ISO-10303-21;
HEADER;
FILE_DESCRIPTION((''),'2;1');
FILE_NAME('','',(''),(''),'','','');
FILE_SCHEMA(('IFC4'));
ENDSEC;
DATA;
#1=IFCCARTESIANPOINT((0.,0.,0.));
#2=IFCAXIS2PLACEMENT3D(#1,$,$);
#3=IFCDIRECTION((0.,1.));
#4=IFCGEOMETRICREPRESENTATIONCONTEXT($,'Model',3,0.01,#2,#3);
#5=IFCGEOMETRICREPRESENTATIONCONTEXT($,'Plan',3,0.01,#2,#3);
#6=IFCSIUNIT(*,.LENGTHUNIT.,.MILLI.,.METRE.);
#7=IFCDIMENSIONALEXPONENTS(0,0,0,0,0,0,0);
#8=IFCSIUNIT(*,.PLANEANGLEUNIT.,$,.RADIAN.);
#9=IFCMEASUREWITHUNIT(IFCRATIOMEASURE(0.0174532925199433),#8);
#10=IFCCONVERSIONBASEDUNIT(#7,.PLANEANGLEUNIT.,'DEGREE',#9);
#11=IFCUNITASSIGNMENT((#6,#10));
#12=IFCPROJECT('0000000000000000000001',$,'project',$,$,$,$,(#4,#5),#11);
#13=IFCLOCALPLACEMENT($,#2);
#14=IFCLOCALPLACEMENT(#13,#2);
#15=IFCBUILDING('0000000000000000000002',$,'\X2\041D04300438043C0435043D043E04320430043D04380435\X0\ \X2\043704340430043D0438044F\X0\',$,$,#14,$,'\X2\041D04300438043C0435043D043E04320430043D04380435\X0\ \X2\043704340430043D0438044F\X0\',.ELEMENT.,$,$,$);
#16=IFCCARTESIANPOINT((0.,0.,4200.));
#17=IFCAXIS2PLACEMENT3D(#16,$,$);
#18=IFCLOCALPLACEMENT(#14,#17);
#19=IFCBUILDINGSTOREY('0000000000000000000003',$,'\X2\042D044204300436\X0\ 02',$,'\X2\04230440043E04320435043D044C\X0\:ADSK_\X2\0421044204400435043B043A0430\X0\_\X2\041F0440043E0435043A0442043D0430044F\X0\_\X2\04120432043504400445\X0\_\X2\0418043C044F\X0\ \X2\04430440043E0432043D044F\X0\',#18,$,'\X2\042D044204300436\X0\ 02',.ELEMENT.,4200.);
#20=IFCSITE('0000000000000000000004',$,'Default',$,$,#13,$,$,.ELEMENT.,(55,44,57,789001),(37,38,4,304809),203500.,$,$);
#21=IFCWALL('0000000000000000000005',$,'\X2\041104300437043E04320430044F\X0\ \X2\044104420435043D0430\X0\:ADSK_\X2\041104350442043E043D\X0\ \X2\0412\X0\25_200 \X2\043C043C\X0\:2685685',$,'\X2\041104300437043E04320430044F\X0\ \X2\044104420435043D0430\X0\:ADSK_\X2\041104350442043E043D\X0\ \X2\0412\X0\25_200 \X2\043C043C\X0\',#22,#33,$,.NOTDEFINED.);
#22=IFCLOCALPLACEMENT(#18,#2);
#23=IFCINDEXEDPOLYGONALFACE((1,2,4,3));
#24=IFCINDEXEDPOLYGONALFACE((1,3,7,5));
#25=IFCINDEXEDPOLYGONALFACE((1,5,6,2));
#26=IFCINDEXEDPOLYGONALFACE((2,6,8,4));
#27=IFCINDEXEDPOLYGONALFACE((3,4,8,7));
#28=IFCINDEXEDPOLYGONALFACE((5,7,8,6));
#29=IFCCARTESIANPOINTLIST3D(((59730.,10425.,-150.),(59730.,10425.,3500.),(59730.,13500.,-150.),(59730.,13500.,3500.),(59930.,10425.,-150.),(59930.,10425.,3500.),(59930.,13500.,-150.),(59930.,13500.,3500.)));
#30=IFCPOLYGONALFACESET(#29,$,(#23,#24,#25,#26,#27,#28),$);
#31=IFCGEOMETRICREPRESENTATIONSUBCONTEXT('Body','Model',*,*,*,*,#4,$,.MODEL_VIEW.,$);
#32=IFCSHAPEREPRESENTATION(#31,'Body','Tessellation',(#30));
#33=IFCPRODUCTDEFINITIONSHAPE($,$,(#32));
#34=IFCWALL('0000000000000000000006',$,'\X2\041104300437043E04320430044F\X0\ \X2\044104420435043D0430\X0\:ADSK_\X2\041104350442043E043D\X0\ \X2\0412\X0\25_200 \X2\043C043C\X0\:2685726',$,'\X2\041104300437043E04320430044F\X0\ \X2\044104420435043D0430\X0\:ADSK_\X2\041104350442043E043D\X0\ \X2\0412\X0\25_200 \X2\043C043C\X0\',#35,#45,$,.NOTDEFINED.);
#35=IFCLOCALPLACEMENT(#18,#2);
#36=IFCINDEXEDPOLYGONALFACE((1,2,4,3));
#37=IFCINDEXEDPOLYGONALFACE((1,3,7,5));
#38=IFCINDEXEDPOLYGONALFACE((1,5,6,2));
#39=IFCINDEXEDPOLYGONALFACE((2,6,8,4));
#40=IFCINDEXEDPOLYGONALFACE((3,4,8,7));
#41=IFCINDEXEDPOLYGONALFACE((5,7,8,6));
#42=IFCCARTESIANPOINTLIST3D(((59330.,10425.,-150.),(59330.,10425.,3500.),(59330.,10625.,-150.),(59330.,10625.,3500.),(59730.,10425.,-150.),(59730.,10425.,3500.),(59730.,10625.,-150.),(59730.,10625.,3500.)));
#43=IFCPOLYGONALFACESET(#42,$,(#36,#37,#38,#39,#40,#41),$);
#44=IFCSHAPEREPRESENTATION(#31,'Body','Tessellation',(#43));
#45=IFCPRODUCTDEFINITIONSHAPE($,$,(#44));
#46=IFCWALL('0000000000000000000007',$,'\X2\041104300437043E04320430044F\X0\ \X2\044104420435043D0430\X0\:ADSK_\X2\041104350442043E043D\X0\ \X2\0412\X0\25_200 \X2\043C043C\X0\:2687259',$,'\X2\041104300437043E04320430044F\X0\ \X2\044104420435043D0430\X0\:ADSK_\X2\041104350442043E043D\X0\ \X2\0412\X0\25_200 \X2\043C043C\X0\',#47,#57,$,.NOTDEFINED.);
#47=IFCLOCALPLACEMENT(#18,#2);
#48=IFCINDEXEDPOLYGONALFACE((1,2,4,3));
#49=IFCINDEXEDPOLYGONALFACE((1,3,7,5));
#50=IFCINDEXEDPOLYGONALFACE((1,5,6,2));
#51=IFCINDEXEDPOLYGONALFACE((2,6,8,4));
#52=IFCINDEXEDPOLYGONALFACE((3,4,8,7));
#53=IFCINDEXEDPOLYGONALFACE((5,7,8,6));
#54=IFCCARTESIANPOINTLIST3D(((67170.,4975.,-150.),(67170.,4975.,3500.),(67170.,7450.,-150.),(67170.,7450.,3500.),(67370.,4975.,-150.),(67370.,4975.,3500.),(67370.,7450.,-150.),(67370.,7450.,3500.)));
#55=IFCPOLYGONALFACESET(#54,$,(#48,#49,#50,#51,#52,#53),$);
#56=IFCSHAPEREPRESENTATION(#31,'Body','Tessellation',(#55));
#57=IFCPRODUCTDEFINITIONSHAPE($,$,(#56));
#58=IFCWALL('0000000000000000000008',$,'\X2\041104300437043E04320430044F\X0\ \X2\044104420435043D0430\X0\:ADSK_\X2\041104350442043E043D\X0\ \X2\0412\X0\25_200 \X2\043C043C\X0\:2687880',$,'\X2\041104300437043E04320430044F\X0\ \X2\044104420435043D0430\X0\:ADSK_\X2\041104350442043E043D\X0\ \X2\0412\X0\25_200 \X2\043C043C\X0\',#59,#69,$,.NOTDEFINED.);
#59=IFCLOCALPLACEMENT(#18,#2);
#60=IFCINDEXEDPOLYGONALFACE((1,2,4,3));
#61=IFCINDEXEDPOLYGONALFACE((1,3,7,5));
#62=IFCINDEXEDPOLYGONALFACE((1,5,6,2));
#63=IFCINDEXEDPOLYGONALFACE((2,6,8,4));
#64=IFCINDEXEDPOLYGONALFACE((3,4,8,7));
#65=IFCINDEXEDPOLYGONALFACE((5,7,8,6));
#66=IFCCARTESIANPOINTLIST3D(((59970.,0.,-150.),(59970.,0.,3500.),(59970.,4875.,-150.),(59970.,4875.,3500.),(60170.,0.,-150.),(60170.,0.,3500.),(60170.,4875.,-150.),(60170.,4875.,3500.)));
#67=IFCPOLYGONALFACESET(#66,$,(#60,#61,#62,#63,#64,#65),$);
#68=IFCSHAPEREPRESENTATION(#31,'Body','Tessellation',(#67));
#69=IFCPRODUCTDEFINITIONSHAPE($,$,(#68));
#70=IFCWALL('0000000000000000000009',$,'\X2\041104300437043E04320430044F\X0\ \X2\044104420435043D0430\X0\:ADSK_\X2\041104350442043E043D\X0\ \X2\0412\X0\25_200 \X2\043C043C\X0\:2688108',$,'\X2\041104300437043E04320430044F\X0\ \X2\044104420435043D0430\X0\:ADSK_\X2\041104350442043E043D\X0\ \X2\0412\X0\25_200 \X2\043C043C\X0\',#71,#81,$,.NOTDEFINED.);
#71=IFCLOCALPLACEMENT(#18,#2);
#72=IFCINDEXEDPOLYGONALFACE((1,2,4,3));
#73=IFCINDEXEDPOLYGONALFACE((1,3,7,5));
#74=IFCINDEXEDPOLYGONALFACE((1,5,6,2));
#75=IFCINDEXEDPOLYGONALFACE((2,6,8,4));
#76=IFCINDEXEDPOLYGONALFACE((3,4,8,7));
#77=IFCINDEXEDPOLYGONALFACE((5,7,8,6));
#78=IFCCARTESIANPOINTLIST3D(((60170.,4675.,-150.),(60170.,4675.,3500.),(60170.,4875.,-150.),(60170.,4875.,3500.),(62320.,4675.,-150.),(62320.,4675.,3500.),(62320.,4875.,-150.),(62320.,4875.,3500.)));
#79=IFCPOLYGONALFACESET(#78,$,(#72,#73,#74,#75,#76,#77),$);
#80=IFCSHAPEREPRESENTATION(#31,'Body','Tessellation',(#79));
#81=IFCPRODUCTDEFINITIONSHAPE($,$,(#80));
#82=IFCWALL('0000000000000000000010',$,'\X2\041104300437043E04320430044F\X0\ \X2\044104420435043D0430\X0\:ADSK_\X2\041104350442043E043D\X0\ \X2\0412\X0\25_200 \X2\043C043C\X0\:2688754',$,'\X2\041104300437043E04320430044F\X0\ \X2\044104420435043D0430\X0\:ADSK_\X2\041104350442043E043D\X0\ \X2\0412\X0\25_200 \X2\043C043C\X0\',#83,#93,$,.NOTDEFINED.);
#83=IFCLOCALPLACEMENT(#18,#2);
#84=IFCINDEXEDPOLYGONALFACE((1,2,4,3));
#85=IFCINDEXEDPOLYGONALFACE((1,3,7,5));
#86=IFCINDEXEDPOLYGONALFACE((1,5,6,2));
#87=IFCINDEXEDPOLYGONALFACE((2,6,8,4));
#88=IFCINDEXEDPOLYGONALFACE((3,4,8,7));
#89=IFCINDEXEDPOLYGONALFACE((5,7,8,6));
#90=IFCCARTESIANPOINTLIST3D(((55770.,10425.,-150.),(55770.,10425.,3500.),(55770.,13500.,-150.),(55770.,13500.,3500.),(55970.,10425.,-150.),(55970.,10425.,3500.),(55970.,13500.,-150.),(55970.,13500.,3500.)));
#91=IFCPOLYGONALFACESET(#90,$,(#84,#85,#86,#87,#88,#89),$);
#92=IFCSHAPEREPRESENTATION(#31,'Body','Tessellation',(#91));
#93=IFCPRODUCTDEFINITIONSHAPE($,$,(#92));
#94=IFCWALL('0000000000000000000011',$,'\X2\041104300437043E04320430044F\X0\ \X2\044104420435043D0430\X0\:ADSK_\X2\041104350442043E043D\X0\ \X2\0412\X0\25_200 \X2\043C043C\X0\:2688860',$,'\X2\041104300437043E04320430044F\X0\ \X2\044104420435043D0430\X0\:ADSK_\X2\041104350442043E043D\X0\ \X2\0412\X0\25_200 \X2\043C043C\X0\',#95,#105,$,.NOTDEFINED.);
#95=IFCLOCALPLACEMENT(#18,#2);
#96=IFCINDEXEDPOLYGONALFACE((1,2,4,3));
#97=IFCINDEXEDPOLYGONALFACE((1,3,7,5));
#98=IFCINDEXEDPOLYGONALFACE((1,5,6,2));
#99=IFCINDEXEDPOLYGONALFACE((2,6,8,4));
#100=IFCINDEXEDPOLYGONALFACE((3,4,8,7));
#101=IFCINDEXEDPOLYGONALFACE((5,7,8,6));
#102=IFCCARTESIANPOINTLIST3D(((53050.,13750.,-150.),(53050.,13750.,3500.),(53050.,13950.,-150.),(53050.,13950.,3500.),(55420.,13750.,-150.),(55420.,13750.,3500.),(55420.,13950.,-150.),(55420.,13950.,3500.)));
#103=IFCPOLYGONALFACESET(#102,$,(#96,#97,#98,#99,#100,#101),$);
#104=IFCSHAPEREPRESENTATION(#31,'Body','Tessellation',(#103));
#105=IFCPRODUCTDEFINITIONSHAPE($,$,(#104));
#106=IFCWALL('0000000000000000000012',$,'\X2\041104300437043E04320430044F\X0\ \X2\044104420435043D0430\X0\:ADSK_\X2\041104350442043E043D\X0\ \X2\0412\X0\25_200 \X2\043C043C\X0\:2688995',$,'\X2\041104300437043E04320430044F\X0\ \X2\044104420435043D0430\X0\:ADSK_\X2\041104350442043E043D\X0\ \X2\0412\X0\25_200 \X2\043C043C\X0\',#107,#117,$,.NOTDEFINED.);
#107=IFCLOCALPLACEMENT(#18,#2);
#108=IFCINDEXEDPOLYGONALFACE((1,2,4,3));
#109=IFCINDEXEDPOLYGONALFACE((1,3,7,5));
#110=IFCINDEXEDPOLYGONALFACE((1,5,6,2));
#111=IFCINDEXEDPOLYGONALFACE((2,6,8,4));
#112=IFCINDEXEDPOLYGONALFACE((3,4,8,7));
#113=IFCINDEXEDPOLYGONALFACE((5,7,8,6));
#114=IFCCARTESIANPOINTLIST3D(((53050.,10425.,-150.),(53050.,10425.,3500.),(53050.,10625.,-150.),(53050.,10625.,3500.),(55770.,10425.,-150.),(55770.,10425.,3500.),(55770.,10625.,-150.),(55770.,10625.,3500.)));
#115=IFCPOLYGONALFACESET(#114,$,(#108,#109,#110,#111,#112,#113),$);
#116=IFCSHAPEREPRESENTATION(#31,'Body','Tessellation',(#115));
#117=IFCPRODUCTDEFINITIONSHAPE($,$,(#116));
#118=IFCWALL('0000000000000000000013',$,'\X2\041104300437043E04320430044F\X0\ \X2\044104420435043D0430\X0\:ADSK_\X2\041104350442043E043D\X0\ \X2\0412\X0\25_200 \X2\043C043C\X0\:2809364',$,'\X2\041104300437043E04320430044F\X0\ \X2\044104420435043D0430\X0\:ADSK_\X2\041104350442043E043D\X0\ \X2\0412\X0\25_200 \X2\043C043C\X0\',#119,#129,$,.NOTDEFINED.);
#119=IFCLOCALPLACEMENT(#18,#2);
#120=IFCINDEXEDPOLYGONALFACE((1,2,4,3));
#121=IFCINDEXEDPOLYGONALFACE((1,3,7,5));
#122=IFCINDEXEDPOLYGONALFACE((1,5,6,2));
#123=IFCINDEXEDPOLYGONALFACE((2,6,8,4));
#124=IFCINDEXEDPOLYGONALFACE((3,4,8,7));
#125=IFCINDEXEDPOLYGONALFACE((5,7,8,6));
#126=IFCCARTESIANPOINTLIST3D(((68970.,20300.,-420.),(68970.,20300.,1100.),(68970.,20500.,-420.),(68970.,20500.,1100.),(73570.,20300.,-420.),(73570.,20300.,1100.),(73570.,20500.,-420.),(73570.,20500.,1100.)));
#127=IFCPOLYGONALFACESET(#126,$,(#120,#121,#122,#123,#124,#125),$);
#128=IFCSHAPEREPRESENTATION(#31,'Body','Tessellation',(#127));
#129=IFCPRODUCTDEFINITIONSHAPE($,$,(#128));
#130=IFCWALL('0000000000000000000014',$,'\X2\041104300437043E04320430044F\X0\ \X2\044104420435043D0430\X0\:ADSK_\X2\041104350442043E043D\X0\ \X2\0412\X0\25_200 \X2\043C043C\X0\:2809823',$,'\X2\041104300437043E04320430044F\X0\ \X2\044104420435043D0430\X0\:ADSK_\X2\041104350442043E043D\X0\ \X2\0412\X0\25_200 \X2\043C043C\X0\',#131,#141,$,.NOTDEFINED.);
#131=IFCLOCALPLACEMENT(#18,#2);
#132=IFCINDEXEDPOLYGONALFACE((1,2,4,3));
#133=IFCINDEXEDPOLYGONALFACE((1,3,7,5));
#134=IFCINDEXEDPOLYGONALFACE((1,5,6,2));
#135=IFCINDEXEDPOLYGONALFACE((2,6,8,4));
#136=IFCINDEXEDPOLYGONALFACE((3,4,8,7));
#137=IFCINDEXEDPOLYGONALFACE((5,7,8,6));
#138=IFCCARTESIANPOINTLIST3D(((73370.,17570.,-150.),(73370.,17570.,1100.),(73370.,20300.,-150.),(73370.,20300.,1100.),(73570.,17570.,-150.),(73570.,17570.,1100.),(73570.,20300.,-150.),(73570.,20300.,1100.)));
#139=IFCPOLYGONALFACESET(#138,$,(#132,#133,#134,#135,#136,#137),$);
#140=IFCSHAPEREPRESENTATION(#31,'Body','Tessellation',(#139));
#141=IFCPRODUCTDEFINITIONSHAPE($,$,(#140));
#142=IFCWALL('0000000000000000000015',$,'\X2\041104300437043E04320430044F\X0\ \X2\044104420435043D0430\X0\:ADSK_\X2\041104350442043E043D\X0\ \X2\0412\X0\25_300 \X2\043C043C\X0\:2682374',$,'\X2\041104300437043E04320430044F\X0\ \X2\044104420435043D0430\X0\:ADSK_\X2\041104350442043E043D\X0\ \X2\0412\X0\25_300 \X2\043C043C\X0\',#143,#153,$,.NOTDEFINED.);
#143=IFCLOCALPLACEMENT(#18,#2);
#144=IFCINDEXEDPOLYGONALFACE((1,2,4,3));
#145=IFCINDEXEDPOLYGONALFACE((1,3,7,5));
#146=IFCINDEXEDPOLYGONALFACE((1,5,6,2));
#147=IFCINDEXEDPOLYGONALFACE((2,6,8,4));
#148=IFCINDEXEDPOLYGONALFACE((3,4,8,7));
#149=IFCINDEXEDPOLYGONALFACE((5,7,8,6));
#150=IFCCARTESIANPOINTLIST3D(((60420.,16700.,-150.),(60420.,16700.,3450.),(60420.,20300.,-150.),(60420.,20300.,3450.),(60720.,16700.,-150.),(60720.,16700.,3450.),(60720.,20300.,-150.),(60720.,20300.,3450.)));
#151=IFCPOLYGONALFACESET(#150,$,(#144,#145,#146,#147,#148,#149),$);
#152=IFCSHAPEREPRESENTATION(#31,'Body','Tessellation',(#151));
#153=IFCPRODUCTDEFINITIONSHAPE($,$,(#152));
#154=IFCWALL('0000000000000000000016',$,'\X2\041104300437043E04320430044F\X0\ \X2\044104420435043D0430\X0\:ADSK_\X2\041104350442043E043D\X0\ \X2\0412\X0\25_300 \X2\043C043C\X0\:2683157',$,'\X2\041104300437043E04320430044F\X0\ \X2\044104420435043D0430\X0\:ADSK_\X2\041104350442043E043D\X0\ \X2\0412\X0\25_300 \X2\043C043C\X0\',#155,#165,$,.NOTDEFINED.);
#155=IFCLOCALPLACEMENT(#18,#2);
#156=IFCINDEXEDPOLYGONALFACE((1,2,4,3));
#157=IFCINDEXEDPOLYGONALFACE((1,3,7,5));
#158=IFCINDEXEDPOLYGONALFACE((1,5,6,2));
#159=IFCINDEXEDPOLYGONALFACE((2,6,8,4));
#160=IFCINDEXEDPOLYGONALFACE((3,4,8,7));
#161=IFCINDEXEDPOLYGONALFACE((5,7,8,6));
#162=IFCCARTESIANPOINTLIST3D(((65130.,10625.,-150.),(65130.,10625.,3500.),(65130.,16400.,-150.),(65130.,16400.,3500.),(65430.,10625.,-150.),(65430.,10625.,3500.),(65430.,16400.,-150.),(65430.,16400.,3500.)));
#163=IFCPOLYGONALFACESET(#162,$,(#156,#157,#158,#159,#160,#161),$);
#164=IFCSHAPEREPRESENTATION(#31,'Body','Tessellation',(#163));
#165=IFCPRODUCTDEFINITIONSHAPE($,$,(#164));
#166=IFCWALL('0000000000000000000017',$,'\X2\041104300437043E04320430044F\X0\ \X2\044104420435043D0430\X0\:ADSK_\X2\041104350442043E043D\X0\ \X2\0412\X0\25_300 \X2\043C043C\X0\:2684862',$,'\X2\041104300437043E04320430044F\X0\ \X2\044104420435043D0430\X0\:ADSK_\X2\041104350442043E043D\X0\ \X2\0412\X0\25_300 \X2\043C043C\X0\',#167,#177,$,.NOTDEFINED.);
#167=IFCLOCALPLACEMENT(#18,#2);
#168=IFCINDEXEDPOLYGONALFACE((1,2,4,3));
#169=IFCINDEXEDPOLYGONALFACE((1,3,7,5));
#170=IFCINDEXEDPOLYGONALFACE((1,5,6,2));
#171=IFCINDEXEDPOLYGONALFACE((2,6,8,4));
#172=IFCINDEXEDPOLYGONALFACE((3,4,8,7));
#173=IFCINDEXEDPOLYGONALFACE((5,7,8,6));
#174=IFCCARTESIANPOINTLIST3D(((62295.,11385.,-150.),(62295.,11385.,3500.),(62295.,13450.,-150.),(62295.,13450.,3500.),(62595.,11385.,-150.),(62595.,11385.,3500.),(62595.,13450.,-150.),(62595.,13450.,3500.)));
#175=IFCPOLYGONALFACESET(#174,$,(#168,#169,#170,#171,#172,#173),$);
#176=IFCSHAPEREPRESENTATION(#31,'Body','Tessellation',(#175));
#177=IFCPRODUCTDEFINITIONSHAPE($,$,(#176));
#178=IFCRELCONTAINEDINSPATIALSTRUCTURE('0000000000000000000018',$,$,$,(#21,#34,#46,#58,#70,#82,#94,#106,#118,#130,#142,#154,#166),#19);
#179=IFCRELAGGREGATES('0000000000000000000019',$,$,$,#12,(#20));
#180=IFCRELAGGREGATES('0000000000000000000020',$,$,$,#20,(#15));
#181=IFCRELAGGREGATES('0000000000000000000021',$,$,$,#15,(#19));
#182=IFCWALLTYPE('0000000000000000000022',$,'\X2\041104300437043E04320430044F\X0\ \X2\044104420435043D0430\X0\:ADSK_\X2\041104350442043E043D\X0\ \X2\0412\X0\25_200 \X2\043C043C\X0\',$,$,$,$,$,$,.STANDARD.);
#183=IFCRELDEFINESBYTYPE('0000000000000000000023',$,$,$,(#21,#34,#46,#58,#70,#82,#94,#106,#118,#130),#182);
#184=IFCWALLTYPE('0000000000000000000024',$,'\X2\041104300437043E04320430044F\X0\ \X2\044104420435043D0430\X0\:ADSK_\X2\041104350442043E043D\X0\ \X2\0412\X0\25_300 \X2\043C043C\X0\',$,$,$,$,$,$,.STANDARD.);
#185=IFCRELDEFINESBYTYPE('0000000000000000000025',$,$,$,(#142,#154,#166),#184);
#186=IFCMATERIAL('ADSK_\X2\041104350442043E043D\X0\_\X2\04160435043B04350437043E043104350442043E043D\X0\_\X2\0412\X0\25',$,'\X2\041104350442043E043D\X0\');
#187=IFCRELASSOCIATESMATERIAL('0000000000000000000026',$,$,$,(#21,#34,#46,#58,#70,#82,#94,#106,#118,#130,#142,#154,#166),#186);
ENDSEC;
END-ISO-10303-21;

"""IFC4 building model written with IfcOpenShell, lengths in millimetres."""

from ifc_helpers import new_model, entity, si_unit, converted_unit, direction, frame, origin, place, context, subcontext, project, spatial, indexed_curve, outline, extrude, material, type_object, element, save


model = new_model("IFC4")

# Units and contexts
model_context = context("Model", 3, precision=0.01, world=origin(), true_north=direction((0.0, 1.0)))
plan_context = context("Plan", 3, precision=0.01, world=origin(), true_north=direction((0.0, 1.0)))
body_context = subcontext(model_context, "Body", "Model", "MODEL_VIEW")
ifc_project = project(units=[si_unit("LENGTHUNIT", "METRE", prefix="MILLI"), converted_unit("PLANEANGLEUNIT", "DEGREE", entity("IfcRatioMeasure", 0.0174532925199433), si_unit("PLANEANGLEUNIT", "RADIAN"), dimensions=[0, 0, 0, 0, 0, 0, 0])], contexts=[model_context, plan_context])

# Site, building, storey
site_placement = place(None, origin())
site = spatial("IfcSite", under=ifc_project, at=site_placement, Name="Default", CompositionType="ELEMENT", RefLatitude=(55, 44, 57, 789001), RefLongitude=(37, 38, 4, 304809), RefElevation=203500.0)
building_placement = place(site_placement, origin())
building = spatial("IfcBuilding", under=site, at=building_placement, Name="Наименование здания", LongName="Наименование здания", CompositionType="ELEMENT")
storey_placement = place(building_placement, frame((0.0, 0.0, 4200.0)))
storey = spatial("IfcBuildingStorey", under=building, at=storey_placement, Name="Этаж 02", ObjectType="Уровень:ADSK_Стрелка_Проектная_Вверх_Имя уровня", LongName="Этаж 02", CompositionType="ELEMENT", Elevation=4200.0)

# Walls
ifc_material = material(Name="ADSK_Бетон_Железобетон_В25", Category="Бетон")
wall_type_1 = type_object("IfcWallType", Name="Базовая стена:ADSK_Бетон В25_200 мм", PredefinedType="STANDARD")
wall_1_placement = place(storey_placement, frame((59830.0, 13500.0, -150.0), z_axis=(0.0, 0.0, 1.0), x_axis=(0.0, -1.0, 0.0)))
element("IfcWall", 1, at=wall_1_placement, inside=storey, type_object=wall_type_1, material=ifc_material, Name="Базовая стена:ADSK_Бетон В25_200 мм:2685685", ObjectType="Базовая стена:ADSK_Бетон В25_200 мм", PredefinedType="NOTDEFINED", context=body_context, shape_type="SweptSolid", body=[
    extrude(outline(indexed_curve([(3075.0, 100.0), (0.0, 100.0), (0.0, -100.0), (3075.0, -100.0), (3075.0, 100.0)], self_intersect=False)), origin(), (0.0, 0.0, 1.0), 3650.0),
])
wall_2_placement = place(storey_placement, frame((59730.0, 10525.0, -150.0), z_axis=(0.0, 0.0, 1.0), x_axis=(-1.0, 0.0, 0.0)))
element("IfcWall", 2, at=wall_2_placement, inside=storey, type_object=wall_type_1, material=ifc_material, Name="Базовая стена:ADSK_Бетон В25_200 мм:2685726", ObjectType="Базовая стена:ADSK_Бетон В25_200 мм", PredefinedType="NOTDEFINED", context=body_context, shape_type="SweptSolid", body=[
    extrude(outline(indexed_curve([(400.0, 100.0), (0.0, 100.0), (0.0, -100.0), (400.0, -100.0), (400.0, 100.0)], self_intersect=False)), origin(), (0.0, 0.0, 1.0), 3650.0),
])
wall_3_placement = place(storey_placement, frame((67270.0, 4975.0, -150.0), z_axis=(0.0, 0.0, 1.0), x_axis=(0.0, 1.0, 0.0)))
element("IfcWall", 3, at=wall_3_placement, inside=storey, type_object=wall_type_1, material=ifc_material, Name="Базовая стена:ADSK_Бетон В25_200 мм:2687259", ObjectType="Базовая стена:ADSK_Бетон В25_200 мм", PredefinedType="NOTDEFINED", context=body_context, shape_type="SweptSolid", body=[
    extrude(outline(indexed_curve([(2475.0, 100.0), (0.0, 100.0), (0.0, -100.0), (2475.0, -100.0), (2475.0, 100.0)], self_intersect=False)), origin(), (0.0, 0.0, 1.0), 3650.0),
])
wall_4_placement = place(storey_placement, frame((60070.0, 0.0, -150.0), z_axis=(0.0, 0.0, 1.0), x_axis=(0.0, 1.0, 0.0)))
element("IfcWall", 4, at=wall_4_placement, inside=storey, type_object=wall_type_1, material=ifc_material, Name="Базовая стена:ADSK_Бетон В25_200 мм:2687880", ObjectType="Базовая стена:ADSK_Бетон В25_200 мм", PredefinedType="NOTDEFINED", context=body_context, shape_type="SweptSolid", body=[
    extrude(outline(indexed_curve([(4875.0, 100.0), (0.0, 100.0), (0.0, -100.0), (4875.0, -100.0), (4875.0, 100.0)], self_intersect=False)), origin(), (0.0, 0.0, 1.0), 3650.0),
])
wall_5_placement = place(storey_placement, frame((62320.0, 4775.0, -150.0), z_axis=(0.0, 0.0, 1.0), x_axis=(-1.0, 0.0, 0.0)))
element("IfcWall", 5, at=wall_5_placement, inside=storey, type_object=wall_type_1, material=ifc_material, Name="Базовая стена:ADSK_Бетон В25_200 мм:2688108", ObjectType="Базовая стена:ADSK_Бетон В25_200 мм", PredefinedType="NOTDEFINED", context=body_context, shape_type="SweptSolid", body=[
    extrude(outline(indexed_curve([(2150.0, 100.0), (0.0, 100.0), (0.0, -100.0), (2150.0, -100.0), (2150.0, 100.0)], self_intersect=False)), origin(), (0.0, 0.0, 1.0), 3650.0),
])
wall_6_placement = place(storey_placement, frame((55870.0, 13500.0, -150.0), z_axis=(0.0, 0.0, 1.0), x_axis=(0.0, -1.0, 0.0)))
element("IfcWall", 6, at=wall_6_placement, inside=storey, type_object=wall_type_1, material=ifc_material, Name="Базовая стена:ADSK_Бетон В25_200 мм:2688754", ObjectType="Базовая стена:ADSK_Бетон В25_200 мм", PredefinedType="NOTDEFINED", context=body_context, shape_type="SweptSolid", body=[
    extrude(outline(indexed_curve([(3075.0, 100.0), (0.0, 100.0), (0.0, -100.0), (3075.0, -100.0), (3075.0, 100.0)], self_intersect=False)), origin(), (0.0, 0.0, 1.0), 3650.0),
])
wall_7_placement = place(storey_placement, frame((55420.0, 13850.0, -150.0), z_axis=(0.0, 0.0, 1.0), x_axis=(-1.0, 0.0, 0.0)))
element("IfcWall", 7, at=wall_7_placement, inside=storey, type_object=wall_type_1, material=ifc_material, Name="Базовая стена:ADSK_Бетон В25_200 мм:2688860", ObjectType="Базовая стена:ADSK_Бетон В25_200 мм", PredefinedType="NOTDEFINED", context=body_context, shape_type="SweptSolid", body=[
    extrude(outline(indexed_curve([(2370.0, 100.0), (0.0, 100.0), (0.0, -100.0), (2370.0, -100.0), (2370.0, 100.0)], self_intersect=False)), origin(), (0.0, 0.0, 1.0), 3650.0),
])
wall_8_placement = place(storey_placement, frame((55770.0, 10525.0, -150.0), z_axis=(0.0, 0.0, 1.0), x_axis=(-1.0, 0.0, 0.0)))
element("IfcWall", 8, at=wall_8_placement, inside=storey, type_object=wall_type_1, material=ifc_material, Name="Базовая стена:ADSK_Бетон В25_200 мм:2688995", ObjectType="Базовая стена:ADSK_Бетон В25_200 мм", PredefinedType="NOTDEFINED", context=body_context, shape_type="SweptSolid", body=[
    extrude(outline(indexed_curve([(2720.0, 100.0), (0.0, 100.0), (0.0, -100.0), (2720.0, -100.0), (2720.0, 100.0)], self_intersect=False)), origin(), (0.0, 0.0, 1.0), 3650.0),
])
wall_9_placement = place(storey_placement, frame((68970.0, 20400.0, -420.0)))
element("IfcWall", 9, at=wall_9_placement, inside=storey, type_object=wall_type_1, material=ifc_material, Name="Базовая стена:ADSK_Бетон В25_200 мм:2809364", ObjectType="Базовая стена:ADSK_Бетон В25_200 мм", PredefinedType="NOTDEFINED", context=body_context, shape_type="SweptSolid", body=[
    extrude(outline(indexed_curve([(4600.0, 100.0), (0.0, 100.0), (0.0, -100.0), (4600.0, -100.0), (4600.0, 100.0)], self_intersect=False)), origin(), (0.0, 0.0, 1.0), 1520.0),
])
wall_10_placement = place(storey_placement, frame((73470.0, 17570.0, -150.0), z_axis=(0.0, 0.0, 1.0), x_axis=(0.0, 1.0, 0.0)))
element("IfcWall", 10, at=wall_10_placement, inside=storey, type_object=wall_type_1, material=ifc_material, Name="Базовая стена:ADSK_Бетон В25_200 мм:2809823", ObjectType="Базовая стена:ADSK_Бетон В25_200 мм", PredefinedType="NOTDEFINED", context=body_context, shape_type="SweptSolid", body=[
    extrude(outline(indexed_curve([(2730.0, 100.0), (0.0, 100.0), (0.0, -100.0), (2730.0, -100.0), (2730.0, 100.0)], self_intersect=False)), origin(), (0.0, 0.0, 1.0), 1250.0),
])
wall_type_2 = type_object("IfcWallType", Name="Базовая стена:ADSK_Бетон В25_300 мм", PredefinedType="STANDARD")
wall_11_placement = place(storey_placement, frame((60570.0, 20300.0, -150.0), z_axis=(0.0, 0.0, 1.0), x_axis=(0.0, -1.0, 0.0)))
element("IfcWall", 11, at=wall_11_placement, inside=storey, type_object=wall_type_2, material=ifc_material, Name="Базовая стена:ADSK_Бетон В25_300 мм:2682374", ObjectType="Базовая стена:ADSK_Бетон В25_300 мм", PredefinedType="NOTDEFINED", context=body_context, shape_type="SweptSolid", body=[
    extrude(outline(indexed_curve([(3600.0, 150.0), (0.0, 150.0), (0.0, -150.0), (3600.0, -150.0), (3600.0, 150.0)], self_intersect=False)), origin(), (0.0, 0.0, 1.0), 3600.0),
])
wall_12_placement = place(storey_placement, frame((65280.0, 10625.0, -150.0), z_axis=(0.0, 0.0, 1.0), x_axis=(0.0, 1.0, 0.0)))
element("IfcWall", 12, at=wall_12_placement, inside=storey, type_object=wall_type_2, material=ifc_material, Name="Базовая стена:ADSK_Бетон В25_300 мм:2683157", ObjectType="Базовая стена:ADSK_Бетон В25_300 мм", PredefinedType="NOTDEFINED", context=body_context, shape_type="SweptSolid", body=[
    extrude(outline(indexed_curve([(5775.0, 150.0), (0.0, 150.0), (0.0, -150.0), (5775.0, -150.0), (5775.0, 150.0)], self_intersect=False)), origin(), (0.0, 0.0, 1.0), 3650.0),
])
wall_13_placement = place(storey_placement, frame((62445.0, 13450.0, -150.0), z_axis=(0.0, 0.0, 1.0), x_axis=(0.0, -1.0, 0.0)))
element("IfcWall", 13, at=wall_13_placement, inside=storey, type_object=wall_type_2, material=ifc_material, Name="Базовая стена:ADSK_Бетон В25_300 мм:2684862", ObjectType="Базовая стена:ADSK_Бетон В25_300 мм", PredefinedType="NOTDEFINED", context=body_context, shape_type="SweptSolid", body=[
    extrude(outline(indexed_curve([(2065.0, 150.0), (0.0, 150.0), (0.0, -150.0), (2065.0, -150.0), (2065.0, 150.0)], self_intersect=False)), origin(), (0.0, 0.0, 1.0), 3650.0),
])

save(model, "model.ifc")
